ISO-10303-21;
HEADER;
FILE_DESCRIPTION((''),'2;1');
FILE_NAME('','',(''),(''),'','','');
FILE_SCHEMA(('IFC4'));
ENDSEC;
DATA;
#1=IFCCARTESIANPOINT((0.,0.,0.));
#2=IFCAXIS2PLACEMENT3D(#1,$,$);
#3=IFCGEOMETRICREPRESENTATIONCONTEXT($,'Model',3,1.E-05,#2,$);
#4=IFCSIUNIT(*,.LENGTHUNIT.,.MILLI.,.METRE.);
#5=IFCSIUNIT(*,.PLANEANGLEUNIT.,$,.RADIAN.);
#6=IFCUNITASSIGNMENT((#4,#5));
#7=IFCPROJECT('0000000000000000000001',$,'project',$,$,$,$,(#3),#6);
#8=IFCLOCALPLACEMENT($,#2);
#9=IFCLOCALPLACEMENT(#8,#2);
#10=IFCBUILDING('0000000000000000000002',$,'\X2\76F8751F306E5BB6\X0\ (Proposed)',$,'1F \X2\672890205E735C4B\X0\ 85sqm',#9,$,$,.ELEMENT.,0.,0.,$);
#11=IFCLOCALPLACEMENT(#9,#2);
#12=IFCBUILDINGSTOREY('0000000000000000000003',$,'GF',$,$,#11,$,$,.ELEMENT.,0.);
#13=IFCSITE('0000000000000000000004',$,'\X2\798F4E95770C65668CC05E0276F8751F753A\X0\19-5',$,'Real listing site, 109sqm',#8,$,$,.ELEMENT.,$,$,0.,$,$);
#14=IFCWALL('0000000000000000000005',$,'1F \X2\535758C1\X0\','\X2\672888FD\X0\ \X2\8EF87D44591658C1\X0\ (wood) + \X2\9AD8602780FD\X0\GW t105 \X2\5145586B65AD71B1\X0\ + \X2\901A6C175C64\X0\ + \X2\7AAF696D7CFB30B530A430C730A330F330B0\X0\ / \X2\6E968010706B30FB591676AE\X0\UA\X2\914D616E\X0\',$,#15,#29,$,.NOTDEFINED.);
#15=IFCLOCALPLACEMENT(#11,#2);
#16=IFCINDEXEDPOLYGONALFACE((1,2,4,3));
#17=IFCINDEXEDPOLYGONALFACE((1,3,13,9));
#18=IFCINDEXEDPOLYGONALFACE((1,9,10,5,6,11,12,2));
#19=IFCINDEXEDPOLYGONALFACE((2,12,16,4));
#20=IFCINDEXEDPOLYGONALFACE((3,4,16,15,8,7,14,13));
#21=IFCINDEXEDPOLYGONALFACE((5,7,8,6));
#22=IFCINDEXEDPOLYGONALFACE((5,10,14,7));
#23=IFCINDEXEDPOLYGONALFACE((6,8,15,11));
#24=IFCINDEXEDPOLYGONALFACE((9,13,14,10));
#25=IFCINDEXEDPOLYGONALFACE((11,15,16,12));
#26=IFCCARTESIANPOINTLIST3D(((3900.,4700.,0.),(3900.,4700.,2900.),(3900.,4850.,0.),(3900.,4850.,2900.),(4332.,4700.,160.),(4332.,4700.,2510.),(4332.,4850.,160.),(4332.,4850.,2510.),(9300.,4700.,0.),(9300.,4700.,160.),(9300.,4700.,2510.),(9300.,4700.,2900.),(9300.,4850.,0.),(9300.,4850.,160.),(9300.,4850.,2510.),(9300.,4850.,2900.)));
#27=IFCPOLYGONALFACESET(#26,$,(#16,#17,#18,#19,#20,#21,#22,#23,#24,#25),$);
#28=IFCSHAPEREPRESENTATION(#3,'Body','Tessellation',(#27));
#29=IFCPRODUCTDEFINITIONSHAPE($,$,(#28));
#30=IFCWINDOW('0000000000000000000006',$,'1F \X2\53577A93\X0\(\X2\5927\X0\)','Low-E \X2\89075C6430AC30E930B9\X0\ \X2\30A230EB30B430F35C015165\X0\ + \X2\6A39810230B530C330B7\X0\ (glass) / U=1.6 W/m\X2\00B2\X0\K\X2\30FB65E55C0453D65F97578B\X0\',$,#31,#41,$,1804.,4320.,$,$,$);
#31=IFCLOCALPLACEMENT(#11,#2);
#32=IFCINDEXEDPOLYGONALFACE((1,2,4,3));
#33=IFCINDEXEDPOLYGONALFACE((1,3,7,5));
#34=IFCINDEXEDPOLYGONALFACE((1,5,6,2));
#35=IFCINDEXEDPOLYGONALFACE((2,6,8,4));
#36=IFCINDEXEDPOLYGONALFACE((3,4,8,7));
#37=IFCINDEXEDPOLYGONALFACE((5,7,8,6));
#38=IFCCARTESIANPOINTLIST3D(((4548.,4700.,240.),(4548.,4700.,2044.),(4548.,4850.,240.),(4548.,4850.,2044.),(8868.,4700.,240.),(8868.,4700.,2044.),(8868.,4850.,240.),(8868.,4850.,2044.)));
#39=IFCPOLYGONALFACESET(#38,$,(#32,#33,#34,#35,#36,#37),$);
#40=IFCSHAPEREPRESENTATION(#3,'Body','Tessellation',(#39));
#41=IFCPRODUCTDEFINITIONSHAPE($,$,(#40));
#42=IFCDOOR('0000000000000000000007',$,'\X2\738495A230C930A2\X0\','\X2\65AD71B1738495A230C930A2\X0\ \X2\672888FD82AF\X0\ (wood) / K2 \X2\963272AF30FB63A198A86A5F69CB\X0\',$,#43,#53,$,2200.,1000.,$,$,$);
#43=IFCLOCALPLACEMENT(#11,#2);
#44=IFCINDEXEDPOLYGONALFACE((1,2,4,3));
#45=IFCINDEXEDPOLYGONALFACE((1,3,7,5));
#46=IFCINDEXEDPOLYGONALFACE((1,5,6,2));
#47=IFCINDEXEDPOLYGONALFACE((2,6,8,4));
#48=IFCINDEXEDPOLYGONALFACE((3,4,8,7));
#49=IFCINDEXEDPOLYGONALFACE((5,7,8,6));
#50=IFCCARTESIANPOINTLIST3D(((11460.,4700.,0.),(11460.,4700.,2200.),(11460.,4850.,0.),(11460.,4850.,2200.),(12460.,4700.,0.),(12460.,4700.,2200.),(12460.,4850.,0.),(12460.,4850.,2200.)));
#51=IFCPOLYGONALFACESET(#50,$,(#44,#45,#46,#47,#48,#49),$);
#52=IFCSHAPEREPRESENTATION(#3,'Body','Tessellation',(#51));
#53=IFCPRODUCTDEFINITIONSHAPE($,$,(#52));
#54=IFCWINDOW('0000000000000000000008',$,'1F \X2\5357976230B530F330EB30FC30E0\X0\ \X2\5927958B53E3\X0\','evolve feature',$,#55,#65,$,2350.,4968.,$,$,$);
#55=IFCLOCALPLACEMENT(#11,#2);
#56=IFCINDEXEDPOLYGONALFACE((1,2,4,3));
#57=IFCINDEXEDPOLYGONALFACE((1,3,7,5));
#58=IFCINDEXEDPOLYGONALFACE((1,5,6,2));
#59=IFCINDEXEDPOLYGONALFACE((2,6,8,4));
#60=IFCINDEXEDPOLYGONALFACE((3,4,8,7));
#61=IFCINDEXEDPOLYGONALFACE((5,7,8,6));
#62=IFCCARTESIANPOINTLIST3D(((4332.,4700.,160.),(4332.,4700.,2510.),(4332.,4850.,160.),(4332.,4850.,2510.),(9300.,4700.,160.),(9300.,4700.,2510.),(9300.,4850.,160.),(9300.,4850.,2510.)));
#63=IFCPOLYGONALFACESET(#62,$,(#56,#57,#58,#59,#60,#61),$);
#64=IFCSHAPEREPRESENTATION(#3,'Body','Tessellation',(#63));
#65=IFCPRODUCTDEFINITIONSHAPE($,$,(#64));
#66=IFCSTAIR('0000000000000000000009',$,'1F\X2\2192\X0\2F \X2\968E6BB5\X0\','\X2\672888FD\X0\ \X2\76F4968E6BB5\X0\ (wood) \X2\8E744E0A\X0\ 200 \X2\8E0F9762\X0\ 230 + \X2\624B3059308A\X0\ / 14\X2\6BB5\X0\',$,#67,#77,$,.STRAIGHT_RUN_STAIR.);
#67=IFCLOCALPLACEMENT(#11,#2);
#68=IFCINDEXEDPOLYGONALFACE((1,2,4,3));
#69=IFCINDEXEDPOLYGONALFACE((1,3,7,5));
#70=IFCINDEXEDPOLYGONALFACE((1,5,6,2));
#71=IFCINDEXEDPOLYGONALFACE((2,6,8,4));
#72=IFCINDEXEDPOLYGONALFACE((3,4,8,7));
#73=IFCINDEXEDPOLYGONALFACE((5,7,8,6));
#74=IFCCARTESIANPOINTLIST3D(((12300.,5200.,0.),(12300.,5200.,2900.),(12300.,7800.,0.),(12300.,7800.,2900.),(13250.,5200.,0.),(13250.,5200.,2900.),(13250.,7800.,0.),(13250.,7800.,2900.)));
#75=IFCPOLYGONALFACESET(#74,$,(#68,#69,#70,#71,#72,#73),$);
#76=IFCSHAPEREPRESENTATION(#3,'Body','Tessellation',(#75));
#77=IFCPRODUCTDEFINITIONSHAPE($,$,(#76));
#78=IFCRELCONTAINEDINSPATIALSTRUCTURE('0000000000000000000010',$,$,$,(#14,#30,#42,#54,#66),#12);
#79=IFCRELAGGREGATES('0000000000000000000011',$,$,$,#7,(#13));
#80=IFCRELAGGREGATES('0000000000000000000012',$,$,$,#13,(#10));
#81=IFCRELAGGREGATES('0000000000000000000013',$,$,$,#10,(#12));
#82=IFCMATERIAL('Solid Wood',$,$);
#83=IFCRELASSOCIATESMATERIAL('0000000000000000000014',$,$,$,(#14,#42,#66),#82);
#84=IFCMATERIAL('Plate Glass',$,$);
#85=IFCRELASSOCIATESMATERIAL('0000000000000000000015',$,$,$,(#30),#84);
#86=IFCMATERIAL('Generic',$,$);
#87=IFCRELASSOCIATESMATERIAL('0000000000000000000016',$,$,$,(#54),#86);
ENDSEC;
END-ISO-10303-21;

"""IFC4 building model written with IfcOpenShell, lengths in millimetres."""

from ifc_helpers import new_model, si_unit, frame, frame_2d, origin, place, context, project, spatial, rectangle, extrude, material, element, fill, save


model = new_model("IFC4")

# Units and contexts
model_context = context("Model", 3, precision=1e-05, world=origin())
ifc_project = project(units=[si_unit("LENGTHUNIT", "METRE", prefix="MILLI"), si_unit("PLANEANGLEUNIT", "RADIAN")], contexts=[model_context])

# Site, building, storey
site_placement = place(None, origin())
site = spatial("IfcSite", under=ifc_project, at=site_placement, Name="福井県敦賀市相生町19-5", ObjectType="Real listing site, 109sqm", CompositionType="ELEMENT", RefElevation=0.0)
building_placement = place(site_placement, origin())
building = spatial("IfcBuilding", under=site, at=building_placement, Name="相生の家 (Proposed)", ObjectType="1F 木造平屋 85sqm", CompositionType="ELEMENT", ElevationOfRefHeight=0.0, ElevationOfTerrain=0.0)
storey_placement = place(building_placement, origin())
storey = spatial("IfcBuildingStorey", under=building, at=storey_placement, Name="GF", CompositionType="ELEMENT", Elevation=0.0)

# Shared definitions
ifc_material_1 = material(Name="Solid Wood")

# Wall, openings, windows, door
wall_1_placement = place(storey_placement, frame((1950.0, 2350.0, 0.0)))
wall_1 = element("IfcWall", 1, at=wall_1_placement, inside=storey, material=ifc_material_1, Name="1F 南壁", Description="木製 軸組外壁 (wood) + 高性能GW t105 充填断熱 + 通気層 + 窯業系サイディング / 準耐火・外皮UA配慮", PredefinedType="NOTDEFINED", context=model_context, shape_type="SweptSolid", body=[
    extrude(rectangle(XDim=5400.0, YDim=150.0, at=frame_2d((2700.0, 75.0))), frame((1950.0, 2350.0, 0.0)), (0.0, 0.0, 1.0), 2900.0),
])
opening_1_placement = place(storey_placement, frame((2274.0, 2350.0, 120.0)))
opening_1 = element("IfcOpeningElement", 2, at=opening_1_placement, cuts=wall_1, PredefinedType="NOTDEFINED", context=model_context, shape_type="SweptSolid", body=[
    extrude(rectangle(XDim=4320.0, YDim=150.0, at=frame_2d((2160.0, 75.0))), frame((2274.0, 2350.0, 120.0)), (0.0, 0.0, 1.0), 1804.0),
])
opening_2_placement = place(storey_placement, frame((5730.0, 2350.0, 0.0)))
opening_2 = element("IfcOpeningElement", 3, at=opening_2_placement, cuts=wall_1, PredefinedType="NOTDEFINED", context=model_context, shape_type="SweptSolid", body=[
    extrude(rectangle(XDim=1000.0, YDim=150.0, at=frame_2d((500.0, 75.0))), frame((5730.0, 2350.0, 0.0)), (0.0, 0.0, 1.0), 2200.0),
])
opening_3_placement = place(storey_placement, frame((2166.0, 2350.0, 80.0)))
opening_3 = element("IfcOpeningElement", 4, at=opening_3_placement, cuts=wall_1, PredefinedType="NOTDEFINED", context=model_context, shape_type="SweptSolid", body=[
    extrude(rectangle(XDim=4968.0, YDim=150.0, at=frame_2d((2484.0, 75.0))), frame((2166.0, 2350.0, 80.0)), (0.0, 0.0, 1.0), 2350.0),
])
ifc_material_2 = material(Name="Plate Glass")
window_1_placement = place(storey_placement, frame((2274.0, 2350.0, 120.0)))
window_1 = element("IfcWindow", 5, at=window_1_placement, inside=storey, material=ifc_material_2, Name="1F 南窓(大)", Description="Low-E 複層ガラス アルゴン封入 + 樹脂サッシ (glass) / U=1.6 W/m²K・日射取得型", OverallHeight=1804.0, OverallWidth=4320.0, context=model_context, shape_type="SweptSolid", body=[
    extrude(rectangle(XDim=4320.0, YDim=150.0, at=frame_2d((2160.0, 75.0))), frame((2274.0, 2350.0, 120.0)), (0.0, 0.0, 1.0), 1804.0),
])
fill(opening_1, window_1)
door_1_placement = place(storey_placement, frame((5730.0, 2350.0, 0.0)))
door_1 = element("IfcDoor", 6, at=door_1_placement, inside=storey, material=ifc_material_1, Name="玄関ドア", Description="断熱玄関ドア 木製芯 (wood) / K2 防犯・採風機構", OverallHeight=2200.0, OverallWidth=1000.0, context=model_context, shape_type="SweptSolid", body=[
    extrude(rectangle(XDim=1000.0, YDim=150.0, at=frame_2d((500.0, 75.0))), frame((5730.0, 2350.0, 0.0)), (0.0, 0.0, 1.0), 2200.0),
])
fill(opening_2, door_1)
ifc_material_3 = material(Name="Generic")
window_2_placement = place(storey_placement, frame((2166.0, 2350.0, 80.0)))
window_2 = element("IfcWindow", 7, at=window_2_placement, inside=storey, material=ifc_material_3, Name="1F 南面サンルーム 大開口", Description="evolve feature", OverallHeight=2350.0, OverallWidth=4968.0, context=model_context, shape_type="SweptSolid", body=[
    extrude(rectangle(XDim=4968.0, YDim=150.0, at=frame_2d((2484.0, 75.0))), frame((2166.0, 2350.0, 80.0)), (0.0, 0.0, 1.0), 2350.0),
])
fill(opening_3, window_2)

# Stair
stair_placement = place(storey_placement, frame((6150.0, 2600.0, 0.0)))
element("IfcStair", 8, at=stair_placement, inside=storey, material=ifc_material_1, Name="1F→2F 階段", Description="木製 直階段 (wood) 蹴上 200 踏面 230 + 手すり / 14段", PredefinedType="STRAIGHT_RUN_STAIR", context=model_context, shape_type="SweptSolid", body=[
    extrude(rectangle(XDim=950.0, YDim=2600.0, at=frame_2d((475.0, 1300.0))), frame((6150.0, 2600.0, 0.0)), (0.0, 0.0, 1.0), 2900.0),
])

save(model, "model.ifc")
